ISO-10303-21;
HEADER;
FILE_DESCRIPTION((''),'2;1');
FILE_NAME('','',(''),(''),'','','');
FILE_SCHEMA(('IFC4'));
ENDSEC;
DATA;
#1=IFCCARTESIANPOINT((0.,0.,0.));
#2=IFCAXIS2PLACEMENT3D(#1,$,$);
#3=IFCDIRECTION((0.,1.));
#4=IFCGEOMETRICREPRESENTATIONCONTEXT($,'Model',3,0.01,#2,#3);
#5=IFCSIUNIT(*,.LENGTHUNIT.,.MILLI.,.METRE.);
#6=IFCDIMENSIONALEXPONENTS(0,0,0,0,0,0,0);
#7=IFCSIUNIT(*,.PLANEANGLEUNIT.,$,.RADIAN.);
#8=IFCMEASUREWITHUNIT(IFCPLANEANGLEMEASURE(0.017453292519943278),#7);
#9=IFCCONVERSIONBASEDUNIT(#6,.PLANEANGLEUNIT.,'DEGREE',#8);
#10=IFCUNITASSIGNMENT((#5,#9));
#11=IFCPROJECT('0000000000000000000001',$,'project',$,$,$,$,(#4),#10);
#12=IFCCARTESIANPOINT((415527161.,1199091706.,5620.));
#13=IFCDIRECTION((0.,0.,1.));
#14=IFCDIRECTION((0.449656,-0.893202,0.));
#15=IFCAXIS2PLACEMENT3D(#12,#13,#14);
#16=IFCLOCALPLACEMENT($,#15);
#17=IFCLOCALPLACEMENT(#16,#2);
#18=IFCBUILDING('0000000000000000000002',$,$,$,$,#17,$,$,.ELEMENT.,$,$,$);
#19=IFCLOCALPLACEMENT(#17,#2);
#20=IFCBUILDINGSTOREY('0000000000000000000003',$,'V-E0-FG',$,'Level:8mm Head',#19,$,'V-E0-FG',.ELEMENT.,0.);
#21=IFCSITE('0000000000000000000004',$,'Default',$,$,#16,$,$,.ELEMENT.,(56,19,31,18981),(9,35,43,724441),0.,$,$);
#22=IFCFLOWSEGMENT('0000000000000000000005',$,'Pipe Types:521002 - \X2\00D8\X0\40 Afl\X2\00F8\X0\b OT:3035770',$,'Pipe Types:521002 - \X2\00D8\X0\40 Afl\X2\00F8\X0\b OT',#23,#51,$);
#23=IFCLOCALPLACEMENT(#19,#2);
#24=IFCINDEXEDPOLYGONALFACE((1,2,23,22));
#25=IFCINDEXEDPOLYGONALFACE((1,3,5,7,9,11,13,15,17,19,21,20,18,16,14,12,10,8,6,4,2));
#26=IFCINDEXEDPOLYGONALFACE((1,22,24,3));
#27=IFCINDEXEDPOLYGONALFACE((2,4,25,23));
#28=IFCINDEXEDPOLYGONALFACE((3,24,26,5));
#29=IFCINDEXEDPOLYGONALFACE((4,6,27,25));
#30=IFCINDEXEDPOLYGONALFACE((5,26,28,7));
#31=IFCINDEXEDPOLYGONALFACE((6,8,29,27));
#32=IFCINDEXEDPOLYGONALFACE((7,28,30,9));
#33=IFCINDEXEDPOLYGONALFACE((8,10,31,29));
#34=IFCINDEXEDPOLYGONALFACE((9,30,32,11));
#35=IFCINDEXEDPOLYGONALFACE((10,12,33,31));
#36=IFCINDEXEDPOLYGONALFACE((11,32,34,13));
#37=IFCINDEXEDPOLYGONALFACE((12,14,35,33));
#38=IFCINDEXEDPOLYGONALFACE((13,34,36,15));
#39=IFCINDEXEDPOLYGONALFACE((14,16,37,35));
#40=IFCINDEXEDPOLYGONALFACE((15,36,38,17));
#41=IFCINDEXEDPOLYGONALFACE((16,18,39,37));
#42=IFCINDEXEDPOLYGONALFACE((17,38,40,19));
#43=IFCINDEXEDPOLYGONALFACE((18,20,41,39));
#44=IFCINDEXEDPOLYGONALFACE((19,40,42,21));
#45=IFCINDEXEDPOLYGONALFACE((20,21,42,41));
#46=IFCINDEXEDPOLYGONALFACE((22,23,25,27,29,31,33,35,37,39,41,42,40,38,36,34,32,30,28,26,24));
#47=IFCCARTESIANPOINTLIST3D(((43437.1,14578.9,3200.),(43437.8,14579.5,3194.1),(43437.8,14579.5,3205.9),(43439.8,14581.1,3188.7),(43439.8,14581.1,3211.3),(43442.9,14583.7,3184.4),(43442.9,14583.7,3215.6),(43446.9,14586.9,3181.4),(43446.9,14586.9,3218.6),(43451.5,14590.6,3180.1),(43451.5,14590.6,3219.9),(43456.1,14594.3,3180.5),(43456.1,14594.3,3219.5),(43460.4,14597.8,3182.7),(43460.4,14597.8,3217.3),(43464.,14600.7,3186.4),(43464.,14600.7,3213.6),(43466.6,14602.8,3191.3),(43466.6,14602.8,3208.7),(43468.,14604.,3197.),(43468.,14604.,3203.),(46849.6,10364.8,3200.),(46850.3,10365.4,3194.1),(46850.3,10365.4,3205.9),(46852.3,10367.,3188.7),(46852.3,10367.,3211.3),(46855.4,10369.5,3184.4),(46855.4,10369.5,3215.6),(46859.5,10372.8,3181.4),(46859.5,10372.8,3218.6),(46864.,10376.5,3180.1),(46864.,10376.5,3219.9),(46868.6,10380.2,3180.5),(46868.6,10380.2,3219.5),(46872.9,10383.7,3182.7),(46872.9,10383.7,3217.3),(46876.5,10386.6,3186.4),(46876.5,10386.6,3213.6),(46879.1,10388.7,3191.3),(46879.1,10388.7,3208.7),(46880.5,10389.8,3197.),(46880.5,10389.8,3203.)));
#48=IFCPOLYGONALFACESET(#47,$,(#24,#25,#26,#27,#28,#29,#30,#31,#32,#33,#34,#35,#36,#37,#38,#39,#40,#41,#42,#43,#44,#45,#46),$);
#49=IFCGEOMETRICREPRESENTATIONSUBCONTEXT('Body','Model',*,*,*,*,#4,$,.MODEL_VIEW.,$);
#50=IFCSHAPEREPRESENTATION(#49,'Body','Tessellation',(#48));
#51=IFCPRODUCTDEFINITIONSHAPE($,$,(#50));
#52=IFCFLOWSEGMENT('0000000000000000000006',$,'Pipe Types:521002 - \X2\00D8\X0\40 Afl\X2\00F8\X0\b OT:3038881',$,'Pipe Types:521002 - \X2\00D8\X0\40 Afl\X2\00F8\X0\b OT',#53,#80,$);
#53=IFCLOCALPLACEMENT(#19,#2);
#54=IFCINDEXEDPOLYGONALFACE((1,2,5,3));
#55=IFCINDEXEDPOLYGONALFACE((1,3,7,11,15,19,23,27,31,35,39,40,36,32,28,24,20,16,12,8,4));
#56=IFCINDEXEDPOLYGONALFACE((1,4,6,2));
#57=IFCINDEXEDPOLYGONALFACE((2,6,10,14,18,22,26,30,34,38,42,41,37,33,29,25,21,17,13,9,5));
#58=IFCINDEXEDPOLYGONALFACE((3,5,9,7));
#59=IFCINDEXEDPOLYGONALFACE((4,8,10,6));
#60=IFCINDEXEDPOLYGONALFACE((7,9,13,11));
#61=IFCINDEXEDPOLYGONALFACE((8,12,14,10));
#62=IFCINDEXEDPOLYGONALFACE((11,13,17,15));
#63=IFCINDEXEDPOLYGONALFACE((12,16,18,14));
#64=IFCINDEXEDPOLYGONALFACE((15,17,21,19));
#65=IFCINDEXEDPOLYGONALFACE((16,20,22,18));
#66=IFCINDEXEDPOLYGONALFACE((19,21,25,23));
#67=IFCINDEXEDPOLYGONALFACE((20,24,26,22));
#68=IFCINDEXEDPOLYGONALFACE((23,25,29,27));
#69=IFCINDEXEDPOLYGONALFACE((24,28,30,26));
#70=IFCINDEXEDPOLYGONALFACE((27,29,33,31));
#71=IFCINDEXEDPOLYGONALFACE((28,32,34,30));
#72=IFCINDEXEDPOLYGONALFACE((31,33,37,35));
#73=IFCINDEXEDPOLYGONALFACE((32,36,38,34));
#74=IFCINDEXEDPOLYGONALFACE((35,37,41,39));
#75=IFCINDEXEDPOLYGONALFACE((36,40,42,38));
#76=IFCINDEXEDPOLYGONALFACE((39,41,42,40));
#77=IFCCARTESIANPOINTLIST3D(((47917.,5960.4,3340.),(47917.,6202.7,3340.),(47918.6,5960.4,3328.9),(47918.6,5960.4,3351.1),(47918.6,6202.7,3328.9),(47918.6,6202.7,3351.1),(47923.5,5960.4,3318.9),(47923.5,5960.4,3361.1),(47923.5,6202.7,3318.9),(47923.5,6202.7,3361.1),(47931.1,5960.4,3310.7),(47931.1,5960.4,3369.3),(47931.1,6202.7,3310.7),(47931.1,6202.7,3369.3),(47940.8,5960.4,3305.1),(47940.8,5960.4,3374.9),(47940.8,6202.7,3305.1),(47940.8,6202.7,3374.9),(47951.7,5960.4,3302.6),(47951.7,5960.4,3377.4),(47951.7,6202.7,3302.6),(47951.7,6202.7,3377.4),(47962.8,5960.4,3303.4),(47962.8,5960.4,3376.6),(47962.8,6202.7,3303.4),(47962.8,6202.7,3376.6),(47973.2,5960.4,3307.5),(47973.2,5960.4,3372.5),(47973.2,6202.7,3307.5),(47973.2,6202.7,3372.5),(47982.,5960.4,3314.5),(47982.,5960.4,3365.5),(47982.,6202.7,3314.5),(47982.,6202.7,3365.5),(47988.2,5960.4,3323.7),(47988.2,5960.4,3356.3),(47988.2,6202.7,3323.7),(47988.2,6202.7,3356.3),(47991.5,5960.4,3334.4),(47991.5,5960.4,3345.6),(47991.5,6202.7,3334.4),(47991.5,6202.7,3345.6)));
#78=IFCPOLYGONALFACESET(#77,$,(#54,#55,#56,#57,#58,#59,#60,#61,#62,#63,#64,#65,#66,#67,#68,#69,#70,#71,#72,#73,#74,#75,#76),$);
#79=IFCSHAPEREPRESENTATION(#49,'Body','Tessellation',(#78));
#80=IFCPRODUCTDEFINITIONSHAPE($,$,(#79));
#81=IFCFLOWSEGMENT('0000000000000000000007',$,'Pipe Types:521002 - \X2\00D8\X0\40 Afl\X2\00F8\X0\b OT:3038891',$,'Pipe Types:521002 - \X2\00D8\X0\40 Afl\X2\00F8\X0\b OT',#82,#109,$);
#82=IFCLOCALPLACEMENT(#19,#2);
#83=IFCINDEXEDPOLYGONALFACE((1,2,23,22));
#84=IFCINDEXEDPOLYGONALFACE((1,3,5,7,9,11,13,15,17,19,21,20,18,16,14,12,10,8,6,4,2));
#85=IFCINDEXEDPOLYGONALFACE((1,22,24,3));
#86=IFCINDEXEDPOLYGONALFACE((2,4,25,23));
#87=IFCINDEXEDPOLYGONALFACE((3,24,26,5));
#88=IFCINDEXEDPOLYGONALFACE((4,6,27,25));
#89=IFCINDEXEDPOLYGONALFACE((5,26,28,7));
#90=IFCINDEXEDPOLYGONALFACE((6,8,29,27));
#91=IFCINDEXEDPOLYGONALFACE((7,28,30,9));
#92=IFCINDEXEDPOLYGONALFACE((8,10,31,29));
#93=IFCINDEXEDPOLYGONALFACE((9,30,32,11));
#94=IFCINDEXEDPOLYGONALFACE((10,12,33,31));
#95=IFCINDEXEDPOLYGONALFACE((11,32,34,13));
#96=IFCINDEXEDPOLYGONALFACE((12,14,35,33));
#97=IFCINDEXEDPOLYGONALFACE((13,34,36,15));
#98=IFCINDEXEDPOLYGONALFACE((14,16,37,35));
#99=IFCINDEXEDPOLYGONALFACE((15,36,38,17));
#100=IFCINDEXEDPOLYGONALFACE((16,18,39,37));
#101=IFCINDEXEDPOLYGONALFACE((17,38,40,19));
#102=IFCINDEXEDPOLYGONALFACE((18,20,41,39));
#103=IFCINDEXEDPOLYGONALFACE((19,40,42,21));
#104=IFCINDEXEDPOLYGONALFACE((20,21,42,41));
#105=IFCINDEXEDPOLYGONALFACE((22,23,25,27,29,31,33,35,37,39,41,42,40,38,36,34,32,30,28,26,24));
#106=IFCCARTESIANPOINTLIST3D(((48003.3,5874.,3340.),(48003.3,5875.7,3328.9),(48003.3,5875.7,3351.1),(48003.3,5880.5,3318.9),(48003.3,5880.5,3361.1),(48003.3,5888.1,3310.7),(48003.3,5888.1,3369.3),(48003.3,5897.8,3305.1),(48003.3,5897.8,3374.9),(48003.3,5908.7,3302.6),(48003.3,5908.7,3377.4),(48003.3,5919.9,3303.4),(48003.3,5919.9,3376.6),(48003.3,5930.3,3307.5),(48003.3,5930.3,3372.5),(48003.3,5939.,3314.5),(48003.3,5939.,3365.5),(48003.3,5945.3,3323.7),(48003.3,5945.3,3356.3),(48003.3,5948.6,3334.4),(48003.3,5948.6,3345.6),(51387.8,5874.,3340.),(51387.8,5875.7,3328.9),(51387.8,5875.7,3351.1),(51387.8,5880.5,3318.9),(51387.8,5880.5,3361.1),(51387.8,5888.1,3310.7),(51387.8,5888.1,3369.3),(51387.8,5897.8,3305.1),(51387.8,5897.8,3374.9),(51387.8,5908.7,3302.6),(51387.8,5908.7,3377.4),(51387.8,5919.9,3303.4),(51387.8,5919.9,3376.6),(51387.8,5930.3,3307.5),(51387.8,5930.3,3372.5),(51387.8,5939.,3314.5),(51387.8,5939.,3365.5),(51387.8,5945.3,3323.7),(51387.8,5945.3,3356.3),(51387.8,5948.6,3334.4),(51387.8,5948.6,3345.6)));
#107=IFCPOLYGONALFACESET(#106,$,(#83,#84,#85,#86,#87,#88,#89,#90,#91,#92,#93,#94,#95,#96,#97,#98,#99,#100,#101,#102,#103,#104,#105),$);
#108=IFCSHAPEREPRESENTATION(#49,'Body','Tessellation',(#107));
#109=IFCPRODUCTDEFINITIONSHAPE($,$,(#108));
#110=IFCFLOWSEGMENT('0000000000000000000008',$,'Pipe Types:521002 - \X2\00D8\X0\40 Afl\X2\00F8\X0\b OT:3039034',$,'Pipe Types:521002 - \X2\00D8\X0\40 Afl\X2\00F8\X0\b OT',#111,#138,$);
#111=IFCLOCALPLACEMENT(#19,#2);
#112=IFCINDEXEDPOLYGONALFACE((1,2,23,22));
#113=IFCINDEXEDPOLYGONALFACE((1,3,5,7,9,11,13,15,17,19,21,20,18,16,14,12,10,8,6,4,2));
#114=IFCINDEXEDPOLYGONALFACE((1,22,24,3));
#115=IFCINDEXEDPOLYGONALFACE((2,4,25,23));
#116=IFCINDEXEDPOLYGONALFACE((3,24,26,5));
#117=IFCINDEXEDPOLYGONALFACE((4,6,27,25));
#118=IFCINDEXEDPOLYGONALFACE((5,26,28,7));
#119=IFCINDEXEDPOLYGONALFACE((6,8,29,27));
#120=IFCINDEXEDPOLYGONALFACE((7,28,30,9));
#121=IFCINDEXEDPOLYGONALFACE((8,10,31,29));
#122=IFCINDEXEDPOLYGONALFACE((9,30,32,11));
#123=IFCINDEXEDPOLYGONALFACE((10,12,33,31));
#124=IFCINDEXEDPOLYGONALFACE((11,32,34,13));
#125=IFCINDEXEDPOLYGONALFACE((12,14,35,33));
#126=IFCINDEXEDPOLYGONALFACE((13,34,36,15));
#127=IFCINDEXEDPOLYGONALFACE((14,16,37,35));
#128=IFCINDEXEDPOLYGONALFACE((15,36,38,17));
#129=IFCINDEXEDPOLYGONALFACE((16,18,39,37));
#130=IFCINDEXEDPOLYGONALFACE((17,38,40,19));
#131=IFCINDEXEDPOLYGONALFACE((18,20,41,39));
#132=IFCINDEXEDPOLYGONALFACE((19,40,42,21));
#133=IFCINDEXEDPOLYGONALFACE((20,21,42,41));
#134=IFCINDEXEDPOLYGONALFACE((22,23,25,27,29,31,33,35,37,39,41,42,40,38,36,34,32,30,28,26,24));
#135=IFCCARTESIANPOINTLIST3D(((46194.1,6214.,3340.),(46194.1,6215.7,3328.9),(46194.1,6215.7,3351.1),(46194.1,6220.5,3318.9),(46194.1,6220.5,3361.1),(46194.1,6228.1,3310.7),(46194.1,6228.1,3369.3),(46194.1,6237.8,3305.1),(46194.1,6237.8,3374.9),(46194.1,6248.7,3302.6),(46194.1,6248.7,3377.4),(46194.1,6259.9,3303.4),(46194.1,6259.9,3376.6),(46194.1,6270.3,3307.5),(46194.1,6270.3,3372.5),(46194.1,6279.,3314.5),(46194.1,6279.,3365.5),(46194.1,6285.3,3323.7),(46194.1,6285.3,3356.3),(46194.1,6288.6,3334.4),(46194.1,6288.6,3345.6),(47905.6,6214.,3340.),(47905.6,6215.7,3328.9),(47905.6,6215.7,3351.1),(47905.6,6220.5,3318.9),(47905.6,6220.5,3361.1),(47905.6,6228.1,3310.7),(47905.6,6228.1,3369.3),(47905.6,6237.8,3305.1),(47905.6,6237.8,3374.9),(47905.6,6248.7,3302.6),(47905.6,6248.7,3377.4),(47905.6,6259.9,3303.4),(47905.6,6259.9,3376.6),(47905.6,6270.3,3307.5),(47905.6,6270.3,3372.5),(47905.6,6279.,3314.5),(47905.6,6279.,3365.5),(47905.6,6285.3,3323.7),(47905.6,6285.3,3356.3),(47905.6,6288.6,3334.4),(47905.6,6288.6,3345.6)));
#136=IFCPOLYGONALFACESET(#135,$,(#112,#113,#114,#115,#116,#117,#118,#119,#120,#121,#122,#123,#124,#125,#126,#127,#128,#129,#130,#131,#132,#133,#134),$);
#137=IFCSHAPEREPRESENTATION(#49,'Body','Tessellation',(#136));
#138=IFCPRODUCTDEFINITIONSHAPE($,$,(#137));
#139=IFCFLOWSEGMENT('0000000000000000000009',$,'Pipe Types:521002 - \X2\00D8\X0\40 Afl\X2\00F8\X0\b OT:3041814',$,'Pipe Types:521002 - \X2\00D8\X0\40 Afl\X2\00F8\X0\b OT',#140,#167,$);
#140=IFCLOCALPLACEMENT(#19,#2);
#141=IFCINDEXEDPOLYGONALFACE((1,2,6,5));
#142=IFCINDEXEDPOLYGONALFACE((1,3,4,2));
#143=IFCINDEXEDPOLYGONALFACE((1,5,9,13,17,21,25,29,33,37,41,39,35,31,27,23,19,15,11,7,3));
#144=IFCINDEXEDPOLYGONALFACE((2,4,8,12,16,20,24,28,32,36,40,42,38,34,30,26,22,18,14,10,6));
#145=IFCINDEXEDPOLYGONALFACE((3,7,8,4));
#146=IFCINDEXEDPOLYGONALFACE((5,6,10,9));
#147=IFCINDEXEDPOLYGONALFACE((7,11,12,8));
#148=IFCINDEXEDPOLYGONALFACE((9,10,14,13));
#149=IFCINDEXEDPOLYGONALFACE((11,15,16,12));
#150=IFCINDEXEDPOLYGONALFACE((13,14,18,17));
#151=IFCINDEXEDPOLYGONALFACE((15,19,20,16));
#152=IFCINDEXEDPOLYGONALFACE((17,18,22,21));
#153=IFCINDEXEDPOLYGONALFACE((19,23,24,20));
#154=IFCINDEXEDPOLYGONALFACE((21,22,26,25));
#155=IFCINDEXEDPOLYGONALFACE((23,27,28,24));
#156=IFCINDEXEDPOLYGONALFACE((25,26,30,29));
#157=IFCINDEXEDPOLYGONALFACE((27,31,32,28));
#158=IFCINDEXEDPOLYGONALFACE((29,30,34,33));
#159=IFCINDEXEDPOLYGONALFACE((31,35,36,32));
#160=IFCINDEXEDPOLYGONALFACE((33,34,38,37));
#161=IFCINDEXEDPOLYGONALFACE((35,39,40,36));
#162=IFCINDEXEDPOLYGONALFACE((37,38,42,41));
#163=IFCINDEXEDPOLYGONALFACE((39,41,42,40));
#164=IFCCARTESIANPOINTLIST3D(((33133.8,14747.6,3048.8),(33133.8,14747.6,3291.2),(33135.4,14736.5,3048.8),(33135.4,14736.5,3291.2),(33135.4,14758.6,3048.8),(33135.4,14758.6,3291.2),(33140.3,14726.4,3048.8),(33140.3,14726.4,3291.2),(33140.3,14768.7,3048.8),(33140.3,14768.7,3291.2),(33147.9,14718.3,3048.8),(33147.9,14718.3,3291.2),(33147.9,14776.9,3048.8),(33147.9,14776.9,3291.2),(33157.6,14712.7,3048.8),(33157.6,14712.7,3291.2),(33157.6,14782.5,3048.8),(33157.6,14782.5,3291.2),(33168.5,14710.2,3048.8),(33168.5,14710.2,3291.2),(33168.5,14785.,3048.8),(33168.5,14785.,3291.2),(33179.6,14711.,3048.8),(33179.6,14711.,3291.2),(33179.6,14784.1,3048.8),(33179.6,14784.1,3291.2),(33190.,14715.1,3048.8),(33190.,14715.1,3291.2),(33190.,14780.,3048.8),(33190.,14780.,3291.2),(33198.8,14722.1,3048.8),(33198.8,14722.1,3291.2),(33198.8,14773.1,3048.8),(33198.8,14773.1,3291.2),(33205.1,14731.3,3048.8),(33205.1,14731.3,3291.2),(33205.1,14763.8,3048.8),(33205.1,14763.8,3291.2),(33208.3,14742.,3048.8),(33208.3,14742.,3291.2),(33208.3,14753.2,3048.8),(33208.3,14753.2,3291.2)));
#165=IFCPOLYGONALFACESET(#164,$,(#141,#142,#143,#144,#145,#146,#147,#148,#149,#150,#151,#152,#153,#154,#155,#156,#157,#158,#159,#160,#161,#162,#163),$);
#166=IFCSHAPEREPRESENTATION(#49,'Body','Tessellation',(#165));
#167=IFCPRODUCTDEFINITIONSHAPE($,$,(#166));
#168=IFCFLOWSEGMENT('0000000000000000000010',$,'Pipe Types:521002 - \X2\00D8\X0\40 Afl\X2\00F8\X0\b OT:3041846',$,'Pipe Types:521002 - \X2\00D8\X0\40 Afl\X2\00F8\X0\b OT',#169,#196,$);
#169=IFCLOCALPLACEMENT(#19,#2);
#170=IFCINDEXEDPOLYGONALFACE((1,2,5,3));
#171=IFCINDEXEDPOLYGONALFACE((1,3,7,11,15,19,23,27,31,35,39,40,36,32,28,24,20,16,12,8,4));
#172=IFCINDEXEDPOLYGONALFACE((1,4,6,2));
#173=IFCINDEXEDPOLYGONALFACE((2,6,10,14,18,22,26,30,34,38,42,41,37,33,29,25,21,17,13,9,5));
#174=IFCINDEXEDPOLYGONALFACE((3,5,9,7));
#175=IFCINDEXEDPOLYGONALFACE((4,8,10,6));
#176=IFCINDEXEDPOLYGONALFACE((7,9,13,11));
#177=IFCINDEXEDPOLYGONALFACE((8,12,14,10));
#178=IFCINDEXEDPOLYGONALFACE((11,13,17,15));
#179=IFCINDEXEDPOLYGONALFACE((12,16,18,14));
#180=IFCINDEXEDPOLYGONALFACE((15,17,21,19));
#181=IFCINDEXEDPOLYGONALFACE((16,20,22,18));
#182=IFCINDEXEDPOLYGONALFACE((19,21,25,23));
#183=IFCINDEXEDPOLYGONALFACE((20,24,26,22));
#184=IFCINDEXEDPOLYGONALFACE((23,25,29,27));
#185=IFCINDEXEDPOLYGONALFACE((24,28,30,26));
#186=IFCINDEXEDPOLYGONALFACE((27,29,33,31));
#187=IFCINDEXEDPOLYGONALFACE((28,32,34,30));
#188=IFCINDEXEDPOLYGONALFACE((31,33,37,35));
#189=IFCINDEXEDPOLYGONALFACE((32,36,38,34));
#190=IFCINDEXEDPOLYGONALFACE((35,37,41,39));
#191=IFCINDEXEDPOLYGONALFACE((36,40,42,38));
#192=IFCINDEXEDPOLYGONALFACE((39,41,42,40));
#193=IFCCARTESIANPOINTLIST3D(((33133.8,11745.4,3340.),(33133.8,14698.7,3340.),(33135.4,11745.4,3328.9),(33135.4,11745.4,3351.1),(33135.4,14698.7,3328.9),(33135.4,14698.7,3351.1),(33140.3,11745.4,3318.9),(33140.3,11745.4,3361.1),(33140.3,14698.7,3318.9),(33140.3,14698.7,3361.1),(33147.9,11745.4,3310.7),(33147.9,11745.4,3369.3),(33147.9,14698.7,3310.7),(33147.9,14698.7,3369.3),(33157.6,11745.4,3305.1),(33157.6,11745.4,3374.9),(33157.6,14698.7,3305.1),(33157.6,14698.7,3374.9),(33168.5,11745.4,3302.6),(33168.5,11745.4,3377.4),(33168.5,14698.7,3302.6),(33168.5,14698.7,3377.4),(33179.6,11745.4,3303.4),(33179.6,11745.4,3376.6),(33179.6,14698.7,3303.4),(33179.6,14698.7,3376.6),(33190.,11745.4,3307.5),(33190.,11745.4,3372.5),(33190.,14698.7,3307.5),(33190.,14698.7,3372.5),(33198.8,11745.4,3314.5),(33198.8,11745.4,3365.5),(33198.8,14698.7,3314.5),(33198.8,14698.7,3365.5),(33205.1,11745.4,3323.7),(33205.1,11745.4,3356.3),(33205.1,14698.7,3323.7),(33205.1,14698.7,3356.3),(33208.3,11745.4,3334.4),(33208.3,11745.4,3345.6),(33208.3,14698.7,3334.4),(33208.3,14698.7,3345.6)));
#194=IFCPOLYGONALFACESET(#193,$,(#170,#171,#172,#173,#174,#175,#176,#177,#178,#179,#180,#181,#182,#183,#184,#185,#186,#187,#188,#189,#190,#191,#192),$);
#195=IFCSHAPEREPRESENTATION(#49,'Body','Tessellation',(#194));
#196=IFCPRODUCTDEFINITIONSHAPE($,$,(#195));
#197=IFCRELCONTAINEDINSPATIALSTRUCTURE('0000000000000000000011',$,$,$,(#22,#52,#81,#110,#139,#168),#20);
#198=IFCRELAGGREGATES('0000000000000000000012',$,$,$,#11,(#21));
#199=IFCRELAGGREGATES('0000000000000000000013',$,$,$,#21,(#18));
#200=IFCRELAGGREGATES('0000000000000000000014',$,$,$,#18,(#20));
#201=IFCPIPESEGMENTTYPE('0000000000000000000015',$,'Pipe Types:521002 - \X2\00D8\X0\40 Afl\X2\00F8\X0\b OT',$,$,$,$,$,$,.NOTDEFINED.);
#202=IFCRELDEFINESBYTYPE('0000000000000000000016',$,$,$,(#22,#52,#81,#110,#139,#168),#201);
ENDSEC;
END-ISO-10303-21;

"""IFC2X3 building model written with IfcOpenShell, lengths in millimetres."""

from ifc_helpers import new_model, entity, si_unit, converted_unit, direction, frame, frame_2d, origin, origin_2d_with_axis, place, context, subcontext, project, spatial, circle, extrude, type_object, element, save


model = new_model("IFC2X3")

# Units and contexts
model_context = context("Model", 3, precision=0.01, world=origin(), true_north=direction((0.0, 1.0)))
body_context = subcontext(model_context, "Body", "Model", "MODEL_VIEW")
ifc_project = project(units=[si_unit("LENGTHUNIT", "METRE", prefix="MILLI"), converted_unit("PLANEANGLEUNIT", "DEGREE", entity("IfcPlaneAngleMeasure", 0.017453292519943278), si_unit("PLANEANGLEUNIT", "RADIAN"), dimensions=[0, 0, 0, 0, 0, 0, 0])], contexts=[model_context])

# Site, building, storey
site_placement = place(None, frame((415527161.0, 1199091706.0, 5620.0), z_axis=(0.0, 0.0, 1.0), x_axis=(0.449656, -0.893202, 0.0)))
site = spatial("IfcSite", under=ifc_project, at=site_placement, Name="Default", CompositionType="ELEMENT", RefLatitude=(56, 19, 31, 18981), RefLongitude=(9, 35, 43, 724441), RefElevation=0.0)
building_placement = place(site_placement, origin())
building = spatial("IfcBuilding", under=site, at=building_placement, CompositionType="ELEMENT")
storey_placement = place(building_placement, origin())
storey = spatial("IfcBuildingStorey", under=building, at=storey_placement, Name="V-E0-FG", ObjectType="Level:8mm Head", LongName="V-E0-FG", CompositionType="ELEMENT", Elevation=0.0)

# Flow segments
pipe_segment_type_1 = type_object("IfcPipeSegmentType", Name="Pipe Types:521002 - Ø40 Afløb OT", PredefinedType="NOTDEFINED")
flow_segment_1_placement = place(storey_placement, origin())
element("IfcFlowSegment", 1, at=flow_segment_1_placement, inside=storey, type_object=pipe_segment_type_1, Name="Pipe Types:521002 - Ø40 Afløb OT:3035770", ObjectType="Pipe Types:521002 - Ø40 Afløb OT", context=body_context, shape_type="SweptSolid", body=[
    extrude(circle(Radius=20.0, at=frame_2d((0.0, 0.0), x_axis=(1.0, 0.0))), frame((46865.1, 10377.4, 3200.0), z_axis=(-0.62932, 0.777146, 0.0), x_axis=(-0.777146, -0.62932, 0.0)), (0.0, 0.0, 1.0), 5422.6),
])
flow_segment_2_placement = place(storey_placement, origin())
element("IfcFlowSegment", 2, at=flow_segment_2_placement, inside=storey, type_object=pipe_segment_type_1, Name="Pipe Types:521002 - Ø40 Afløb OT:3038881", ObjectType="Pipe Types:521002 - Ø40 Afløb OT", context=body_context, shape_type="SweptSolid", body=[
    extrude(circle(Radius=37.5, at=frame_2d((0.0, 0.0), x_axis=(1.0, 0.0))), frame((47954.5, 5960.4, 3340.0), z_axis=(0.0, 1.0, 0.0), x_axis=(-1.0, 0.0, 0.0)), (0.0, 0.0, 1.0), 242.3),
])
flow_segment_3_placement = place(storey_placement, origin())
element("IfcFlowSegment", 3, at=flow_segment_3_placement, inside=storey, type_object=pipe_segment_type_1, Name="Pipe Types:521002 - Ø40 Afløb OT:3038891", ObjectType="Pipe Types:521002 - Ø40 Afløb OT", context=body_context, shape_type="SweptSolid", body=[
    extrude(circle(Radius=37.5, at=origin_2d_with_axis()), frame((48003.3, 5911.5, 3340.0), z_axis=(1.0, 0.0, 0.0), x_axis=(0.0, -1.0, 0.0)), (0.0, 0.0, 1.0), 3384.5),
])
flow_segment_4_placement = place(storey_placement, origin())
element("IfcFlowSegment", 4, at=flow_segment_4_placement, inside=storey, type_object=pipe_segment_type_1, Name="Pipe Types:521002 - Ø40 Afløb OT:3039034", ObjectType="Pipe Types:521002 - Ø40 Afløb OT", context=body_context, shape_type="SweptSolid", body=[
    extrude(circle(Radius=37.5, at=origin_2d_with_axis()), frame((46194.1, 6251.5, 3340.0), z_axis=(1.0, 0.0, 0.0), x_axis=(0.0, -1.0, 0.0)), (0.0, 0.0, 1.0), 1711.5),
])
flow_segment_5_placement = place(storey_placement, origin())
element("IfcFlowSegment", 5, at=flow_segment_5_placement, inside=storey, type_object=pipe_segment_type_1, Name="Pipe Types:521002 - Ø40 Afløb OT:3041814", ObjectType="Pipe Types:521002 - Ø40 Afløb OT", context=body_context, shape_type="SweptSolid", body=[
    extrude(circle(Radius=37.5, at=origin_2d_with_axis()), frame((33171.3, 14747.6, 3048.8), z_axis=(0.0, 0.0, 1.0), x_axis=(-1.0, 0.0, 0.0)), (0.0, 0.0, 1.0), 242.3),
])
flow_segment_6_placement = place(storey_placement, origin())
element("IfcFlowSegment", 6, at=flow_segment_6_placement, inside=storey, type_object=pipe_segment_type_1, Name="Pipe Types:521002 - Ø40 Afløb OT:3041846", ObjectType="Pipe Types:521002 - Ø40 Afløb OT", context=body_context, shape_type="SweptSolid", body=[
    extrude(circle(Radius=37.5, at=frame_2d((0.0, 0.0), x_axis=(1.0, 0.0))), frame((33171.3, 11745.4, 3340.0), z_axis=(0.0, 1.0, 0.0), x_axis=(-1.0, 0.0, 0.0)), (0.0, 0.0, 1.0), 2953.3),
])

save(model, "model.ifc")
